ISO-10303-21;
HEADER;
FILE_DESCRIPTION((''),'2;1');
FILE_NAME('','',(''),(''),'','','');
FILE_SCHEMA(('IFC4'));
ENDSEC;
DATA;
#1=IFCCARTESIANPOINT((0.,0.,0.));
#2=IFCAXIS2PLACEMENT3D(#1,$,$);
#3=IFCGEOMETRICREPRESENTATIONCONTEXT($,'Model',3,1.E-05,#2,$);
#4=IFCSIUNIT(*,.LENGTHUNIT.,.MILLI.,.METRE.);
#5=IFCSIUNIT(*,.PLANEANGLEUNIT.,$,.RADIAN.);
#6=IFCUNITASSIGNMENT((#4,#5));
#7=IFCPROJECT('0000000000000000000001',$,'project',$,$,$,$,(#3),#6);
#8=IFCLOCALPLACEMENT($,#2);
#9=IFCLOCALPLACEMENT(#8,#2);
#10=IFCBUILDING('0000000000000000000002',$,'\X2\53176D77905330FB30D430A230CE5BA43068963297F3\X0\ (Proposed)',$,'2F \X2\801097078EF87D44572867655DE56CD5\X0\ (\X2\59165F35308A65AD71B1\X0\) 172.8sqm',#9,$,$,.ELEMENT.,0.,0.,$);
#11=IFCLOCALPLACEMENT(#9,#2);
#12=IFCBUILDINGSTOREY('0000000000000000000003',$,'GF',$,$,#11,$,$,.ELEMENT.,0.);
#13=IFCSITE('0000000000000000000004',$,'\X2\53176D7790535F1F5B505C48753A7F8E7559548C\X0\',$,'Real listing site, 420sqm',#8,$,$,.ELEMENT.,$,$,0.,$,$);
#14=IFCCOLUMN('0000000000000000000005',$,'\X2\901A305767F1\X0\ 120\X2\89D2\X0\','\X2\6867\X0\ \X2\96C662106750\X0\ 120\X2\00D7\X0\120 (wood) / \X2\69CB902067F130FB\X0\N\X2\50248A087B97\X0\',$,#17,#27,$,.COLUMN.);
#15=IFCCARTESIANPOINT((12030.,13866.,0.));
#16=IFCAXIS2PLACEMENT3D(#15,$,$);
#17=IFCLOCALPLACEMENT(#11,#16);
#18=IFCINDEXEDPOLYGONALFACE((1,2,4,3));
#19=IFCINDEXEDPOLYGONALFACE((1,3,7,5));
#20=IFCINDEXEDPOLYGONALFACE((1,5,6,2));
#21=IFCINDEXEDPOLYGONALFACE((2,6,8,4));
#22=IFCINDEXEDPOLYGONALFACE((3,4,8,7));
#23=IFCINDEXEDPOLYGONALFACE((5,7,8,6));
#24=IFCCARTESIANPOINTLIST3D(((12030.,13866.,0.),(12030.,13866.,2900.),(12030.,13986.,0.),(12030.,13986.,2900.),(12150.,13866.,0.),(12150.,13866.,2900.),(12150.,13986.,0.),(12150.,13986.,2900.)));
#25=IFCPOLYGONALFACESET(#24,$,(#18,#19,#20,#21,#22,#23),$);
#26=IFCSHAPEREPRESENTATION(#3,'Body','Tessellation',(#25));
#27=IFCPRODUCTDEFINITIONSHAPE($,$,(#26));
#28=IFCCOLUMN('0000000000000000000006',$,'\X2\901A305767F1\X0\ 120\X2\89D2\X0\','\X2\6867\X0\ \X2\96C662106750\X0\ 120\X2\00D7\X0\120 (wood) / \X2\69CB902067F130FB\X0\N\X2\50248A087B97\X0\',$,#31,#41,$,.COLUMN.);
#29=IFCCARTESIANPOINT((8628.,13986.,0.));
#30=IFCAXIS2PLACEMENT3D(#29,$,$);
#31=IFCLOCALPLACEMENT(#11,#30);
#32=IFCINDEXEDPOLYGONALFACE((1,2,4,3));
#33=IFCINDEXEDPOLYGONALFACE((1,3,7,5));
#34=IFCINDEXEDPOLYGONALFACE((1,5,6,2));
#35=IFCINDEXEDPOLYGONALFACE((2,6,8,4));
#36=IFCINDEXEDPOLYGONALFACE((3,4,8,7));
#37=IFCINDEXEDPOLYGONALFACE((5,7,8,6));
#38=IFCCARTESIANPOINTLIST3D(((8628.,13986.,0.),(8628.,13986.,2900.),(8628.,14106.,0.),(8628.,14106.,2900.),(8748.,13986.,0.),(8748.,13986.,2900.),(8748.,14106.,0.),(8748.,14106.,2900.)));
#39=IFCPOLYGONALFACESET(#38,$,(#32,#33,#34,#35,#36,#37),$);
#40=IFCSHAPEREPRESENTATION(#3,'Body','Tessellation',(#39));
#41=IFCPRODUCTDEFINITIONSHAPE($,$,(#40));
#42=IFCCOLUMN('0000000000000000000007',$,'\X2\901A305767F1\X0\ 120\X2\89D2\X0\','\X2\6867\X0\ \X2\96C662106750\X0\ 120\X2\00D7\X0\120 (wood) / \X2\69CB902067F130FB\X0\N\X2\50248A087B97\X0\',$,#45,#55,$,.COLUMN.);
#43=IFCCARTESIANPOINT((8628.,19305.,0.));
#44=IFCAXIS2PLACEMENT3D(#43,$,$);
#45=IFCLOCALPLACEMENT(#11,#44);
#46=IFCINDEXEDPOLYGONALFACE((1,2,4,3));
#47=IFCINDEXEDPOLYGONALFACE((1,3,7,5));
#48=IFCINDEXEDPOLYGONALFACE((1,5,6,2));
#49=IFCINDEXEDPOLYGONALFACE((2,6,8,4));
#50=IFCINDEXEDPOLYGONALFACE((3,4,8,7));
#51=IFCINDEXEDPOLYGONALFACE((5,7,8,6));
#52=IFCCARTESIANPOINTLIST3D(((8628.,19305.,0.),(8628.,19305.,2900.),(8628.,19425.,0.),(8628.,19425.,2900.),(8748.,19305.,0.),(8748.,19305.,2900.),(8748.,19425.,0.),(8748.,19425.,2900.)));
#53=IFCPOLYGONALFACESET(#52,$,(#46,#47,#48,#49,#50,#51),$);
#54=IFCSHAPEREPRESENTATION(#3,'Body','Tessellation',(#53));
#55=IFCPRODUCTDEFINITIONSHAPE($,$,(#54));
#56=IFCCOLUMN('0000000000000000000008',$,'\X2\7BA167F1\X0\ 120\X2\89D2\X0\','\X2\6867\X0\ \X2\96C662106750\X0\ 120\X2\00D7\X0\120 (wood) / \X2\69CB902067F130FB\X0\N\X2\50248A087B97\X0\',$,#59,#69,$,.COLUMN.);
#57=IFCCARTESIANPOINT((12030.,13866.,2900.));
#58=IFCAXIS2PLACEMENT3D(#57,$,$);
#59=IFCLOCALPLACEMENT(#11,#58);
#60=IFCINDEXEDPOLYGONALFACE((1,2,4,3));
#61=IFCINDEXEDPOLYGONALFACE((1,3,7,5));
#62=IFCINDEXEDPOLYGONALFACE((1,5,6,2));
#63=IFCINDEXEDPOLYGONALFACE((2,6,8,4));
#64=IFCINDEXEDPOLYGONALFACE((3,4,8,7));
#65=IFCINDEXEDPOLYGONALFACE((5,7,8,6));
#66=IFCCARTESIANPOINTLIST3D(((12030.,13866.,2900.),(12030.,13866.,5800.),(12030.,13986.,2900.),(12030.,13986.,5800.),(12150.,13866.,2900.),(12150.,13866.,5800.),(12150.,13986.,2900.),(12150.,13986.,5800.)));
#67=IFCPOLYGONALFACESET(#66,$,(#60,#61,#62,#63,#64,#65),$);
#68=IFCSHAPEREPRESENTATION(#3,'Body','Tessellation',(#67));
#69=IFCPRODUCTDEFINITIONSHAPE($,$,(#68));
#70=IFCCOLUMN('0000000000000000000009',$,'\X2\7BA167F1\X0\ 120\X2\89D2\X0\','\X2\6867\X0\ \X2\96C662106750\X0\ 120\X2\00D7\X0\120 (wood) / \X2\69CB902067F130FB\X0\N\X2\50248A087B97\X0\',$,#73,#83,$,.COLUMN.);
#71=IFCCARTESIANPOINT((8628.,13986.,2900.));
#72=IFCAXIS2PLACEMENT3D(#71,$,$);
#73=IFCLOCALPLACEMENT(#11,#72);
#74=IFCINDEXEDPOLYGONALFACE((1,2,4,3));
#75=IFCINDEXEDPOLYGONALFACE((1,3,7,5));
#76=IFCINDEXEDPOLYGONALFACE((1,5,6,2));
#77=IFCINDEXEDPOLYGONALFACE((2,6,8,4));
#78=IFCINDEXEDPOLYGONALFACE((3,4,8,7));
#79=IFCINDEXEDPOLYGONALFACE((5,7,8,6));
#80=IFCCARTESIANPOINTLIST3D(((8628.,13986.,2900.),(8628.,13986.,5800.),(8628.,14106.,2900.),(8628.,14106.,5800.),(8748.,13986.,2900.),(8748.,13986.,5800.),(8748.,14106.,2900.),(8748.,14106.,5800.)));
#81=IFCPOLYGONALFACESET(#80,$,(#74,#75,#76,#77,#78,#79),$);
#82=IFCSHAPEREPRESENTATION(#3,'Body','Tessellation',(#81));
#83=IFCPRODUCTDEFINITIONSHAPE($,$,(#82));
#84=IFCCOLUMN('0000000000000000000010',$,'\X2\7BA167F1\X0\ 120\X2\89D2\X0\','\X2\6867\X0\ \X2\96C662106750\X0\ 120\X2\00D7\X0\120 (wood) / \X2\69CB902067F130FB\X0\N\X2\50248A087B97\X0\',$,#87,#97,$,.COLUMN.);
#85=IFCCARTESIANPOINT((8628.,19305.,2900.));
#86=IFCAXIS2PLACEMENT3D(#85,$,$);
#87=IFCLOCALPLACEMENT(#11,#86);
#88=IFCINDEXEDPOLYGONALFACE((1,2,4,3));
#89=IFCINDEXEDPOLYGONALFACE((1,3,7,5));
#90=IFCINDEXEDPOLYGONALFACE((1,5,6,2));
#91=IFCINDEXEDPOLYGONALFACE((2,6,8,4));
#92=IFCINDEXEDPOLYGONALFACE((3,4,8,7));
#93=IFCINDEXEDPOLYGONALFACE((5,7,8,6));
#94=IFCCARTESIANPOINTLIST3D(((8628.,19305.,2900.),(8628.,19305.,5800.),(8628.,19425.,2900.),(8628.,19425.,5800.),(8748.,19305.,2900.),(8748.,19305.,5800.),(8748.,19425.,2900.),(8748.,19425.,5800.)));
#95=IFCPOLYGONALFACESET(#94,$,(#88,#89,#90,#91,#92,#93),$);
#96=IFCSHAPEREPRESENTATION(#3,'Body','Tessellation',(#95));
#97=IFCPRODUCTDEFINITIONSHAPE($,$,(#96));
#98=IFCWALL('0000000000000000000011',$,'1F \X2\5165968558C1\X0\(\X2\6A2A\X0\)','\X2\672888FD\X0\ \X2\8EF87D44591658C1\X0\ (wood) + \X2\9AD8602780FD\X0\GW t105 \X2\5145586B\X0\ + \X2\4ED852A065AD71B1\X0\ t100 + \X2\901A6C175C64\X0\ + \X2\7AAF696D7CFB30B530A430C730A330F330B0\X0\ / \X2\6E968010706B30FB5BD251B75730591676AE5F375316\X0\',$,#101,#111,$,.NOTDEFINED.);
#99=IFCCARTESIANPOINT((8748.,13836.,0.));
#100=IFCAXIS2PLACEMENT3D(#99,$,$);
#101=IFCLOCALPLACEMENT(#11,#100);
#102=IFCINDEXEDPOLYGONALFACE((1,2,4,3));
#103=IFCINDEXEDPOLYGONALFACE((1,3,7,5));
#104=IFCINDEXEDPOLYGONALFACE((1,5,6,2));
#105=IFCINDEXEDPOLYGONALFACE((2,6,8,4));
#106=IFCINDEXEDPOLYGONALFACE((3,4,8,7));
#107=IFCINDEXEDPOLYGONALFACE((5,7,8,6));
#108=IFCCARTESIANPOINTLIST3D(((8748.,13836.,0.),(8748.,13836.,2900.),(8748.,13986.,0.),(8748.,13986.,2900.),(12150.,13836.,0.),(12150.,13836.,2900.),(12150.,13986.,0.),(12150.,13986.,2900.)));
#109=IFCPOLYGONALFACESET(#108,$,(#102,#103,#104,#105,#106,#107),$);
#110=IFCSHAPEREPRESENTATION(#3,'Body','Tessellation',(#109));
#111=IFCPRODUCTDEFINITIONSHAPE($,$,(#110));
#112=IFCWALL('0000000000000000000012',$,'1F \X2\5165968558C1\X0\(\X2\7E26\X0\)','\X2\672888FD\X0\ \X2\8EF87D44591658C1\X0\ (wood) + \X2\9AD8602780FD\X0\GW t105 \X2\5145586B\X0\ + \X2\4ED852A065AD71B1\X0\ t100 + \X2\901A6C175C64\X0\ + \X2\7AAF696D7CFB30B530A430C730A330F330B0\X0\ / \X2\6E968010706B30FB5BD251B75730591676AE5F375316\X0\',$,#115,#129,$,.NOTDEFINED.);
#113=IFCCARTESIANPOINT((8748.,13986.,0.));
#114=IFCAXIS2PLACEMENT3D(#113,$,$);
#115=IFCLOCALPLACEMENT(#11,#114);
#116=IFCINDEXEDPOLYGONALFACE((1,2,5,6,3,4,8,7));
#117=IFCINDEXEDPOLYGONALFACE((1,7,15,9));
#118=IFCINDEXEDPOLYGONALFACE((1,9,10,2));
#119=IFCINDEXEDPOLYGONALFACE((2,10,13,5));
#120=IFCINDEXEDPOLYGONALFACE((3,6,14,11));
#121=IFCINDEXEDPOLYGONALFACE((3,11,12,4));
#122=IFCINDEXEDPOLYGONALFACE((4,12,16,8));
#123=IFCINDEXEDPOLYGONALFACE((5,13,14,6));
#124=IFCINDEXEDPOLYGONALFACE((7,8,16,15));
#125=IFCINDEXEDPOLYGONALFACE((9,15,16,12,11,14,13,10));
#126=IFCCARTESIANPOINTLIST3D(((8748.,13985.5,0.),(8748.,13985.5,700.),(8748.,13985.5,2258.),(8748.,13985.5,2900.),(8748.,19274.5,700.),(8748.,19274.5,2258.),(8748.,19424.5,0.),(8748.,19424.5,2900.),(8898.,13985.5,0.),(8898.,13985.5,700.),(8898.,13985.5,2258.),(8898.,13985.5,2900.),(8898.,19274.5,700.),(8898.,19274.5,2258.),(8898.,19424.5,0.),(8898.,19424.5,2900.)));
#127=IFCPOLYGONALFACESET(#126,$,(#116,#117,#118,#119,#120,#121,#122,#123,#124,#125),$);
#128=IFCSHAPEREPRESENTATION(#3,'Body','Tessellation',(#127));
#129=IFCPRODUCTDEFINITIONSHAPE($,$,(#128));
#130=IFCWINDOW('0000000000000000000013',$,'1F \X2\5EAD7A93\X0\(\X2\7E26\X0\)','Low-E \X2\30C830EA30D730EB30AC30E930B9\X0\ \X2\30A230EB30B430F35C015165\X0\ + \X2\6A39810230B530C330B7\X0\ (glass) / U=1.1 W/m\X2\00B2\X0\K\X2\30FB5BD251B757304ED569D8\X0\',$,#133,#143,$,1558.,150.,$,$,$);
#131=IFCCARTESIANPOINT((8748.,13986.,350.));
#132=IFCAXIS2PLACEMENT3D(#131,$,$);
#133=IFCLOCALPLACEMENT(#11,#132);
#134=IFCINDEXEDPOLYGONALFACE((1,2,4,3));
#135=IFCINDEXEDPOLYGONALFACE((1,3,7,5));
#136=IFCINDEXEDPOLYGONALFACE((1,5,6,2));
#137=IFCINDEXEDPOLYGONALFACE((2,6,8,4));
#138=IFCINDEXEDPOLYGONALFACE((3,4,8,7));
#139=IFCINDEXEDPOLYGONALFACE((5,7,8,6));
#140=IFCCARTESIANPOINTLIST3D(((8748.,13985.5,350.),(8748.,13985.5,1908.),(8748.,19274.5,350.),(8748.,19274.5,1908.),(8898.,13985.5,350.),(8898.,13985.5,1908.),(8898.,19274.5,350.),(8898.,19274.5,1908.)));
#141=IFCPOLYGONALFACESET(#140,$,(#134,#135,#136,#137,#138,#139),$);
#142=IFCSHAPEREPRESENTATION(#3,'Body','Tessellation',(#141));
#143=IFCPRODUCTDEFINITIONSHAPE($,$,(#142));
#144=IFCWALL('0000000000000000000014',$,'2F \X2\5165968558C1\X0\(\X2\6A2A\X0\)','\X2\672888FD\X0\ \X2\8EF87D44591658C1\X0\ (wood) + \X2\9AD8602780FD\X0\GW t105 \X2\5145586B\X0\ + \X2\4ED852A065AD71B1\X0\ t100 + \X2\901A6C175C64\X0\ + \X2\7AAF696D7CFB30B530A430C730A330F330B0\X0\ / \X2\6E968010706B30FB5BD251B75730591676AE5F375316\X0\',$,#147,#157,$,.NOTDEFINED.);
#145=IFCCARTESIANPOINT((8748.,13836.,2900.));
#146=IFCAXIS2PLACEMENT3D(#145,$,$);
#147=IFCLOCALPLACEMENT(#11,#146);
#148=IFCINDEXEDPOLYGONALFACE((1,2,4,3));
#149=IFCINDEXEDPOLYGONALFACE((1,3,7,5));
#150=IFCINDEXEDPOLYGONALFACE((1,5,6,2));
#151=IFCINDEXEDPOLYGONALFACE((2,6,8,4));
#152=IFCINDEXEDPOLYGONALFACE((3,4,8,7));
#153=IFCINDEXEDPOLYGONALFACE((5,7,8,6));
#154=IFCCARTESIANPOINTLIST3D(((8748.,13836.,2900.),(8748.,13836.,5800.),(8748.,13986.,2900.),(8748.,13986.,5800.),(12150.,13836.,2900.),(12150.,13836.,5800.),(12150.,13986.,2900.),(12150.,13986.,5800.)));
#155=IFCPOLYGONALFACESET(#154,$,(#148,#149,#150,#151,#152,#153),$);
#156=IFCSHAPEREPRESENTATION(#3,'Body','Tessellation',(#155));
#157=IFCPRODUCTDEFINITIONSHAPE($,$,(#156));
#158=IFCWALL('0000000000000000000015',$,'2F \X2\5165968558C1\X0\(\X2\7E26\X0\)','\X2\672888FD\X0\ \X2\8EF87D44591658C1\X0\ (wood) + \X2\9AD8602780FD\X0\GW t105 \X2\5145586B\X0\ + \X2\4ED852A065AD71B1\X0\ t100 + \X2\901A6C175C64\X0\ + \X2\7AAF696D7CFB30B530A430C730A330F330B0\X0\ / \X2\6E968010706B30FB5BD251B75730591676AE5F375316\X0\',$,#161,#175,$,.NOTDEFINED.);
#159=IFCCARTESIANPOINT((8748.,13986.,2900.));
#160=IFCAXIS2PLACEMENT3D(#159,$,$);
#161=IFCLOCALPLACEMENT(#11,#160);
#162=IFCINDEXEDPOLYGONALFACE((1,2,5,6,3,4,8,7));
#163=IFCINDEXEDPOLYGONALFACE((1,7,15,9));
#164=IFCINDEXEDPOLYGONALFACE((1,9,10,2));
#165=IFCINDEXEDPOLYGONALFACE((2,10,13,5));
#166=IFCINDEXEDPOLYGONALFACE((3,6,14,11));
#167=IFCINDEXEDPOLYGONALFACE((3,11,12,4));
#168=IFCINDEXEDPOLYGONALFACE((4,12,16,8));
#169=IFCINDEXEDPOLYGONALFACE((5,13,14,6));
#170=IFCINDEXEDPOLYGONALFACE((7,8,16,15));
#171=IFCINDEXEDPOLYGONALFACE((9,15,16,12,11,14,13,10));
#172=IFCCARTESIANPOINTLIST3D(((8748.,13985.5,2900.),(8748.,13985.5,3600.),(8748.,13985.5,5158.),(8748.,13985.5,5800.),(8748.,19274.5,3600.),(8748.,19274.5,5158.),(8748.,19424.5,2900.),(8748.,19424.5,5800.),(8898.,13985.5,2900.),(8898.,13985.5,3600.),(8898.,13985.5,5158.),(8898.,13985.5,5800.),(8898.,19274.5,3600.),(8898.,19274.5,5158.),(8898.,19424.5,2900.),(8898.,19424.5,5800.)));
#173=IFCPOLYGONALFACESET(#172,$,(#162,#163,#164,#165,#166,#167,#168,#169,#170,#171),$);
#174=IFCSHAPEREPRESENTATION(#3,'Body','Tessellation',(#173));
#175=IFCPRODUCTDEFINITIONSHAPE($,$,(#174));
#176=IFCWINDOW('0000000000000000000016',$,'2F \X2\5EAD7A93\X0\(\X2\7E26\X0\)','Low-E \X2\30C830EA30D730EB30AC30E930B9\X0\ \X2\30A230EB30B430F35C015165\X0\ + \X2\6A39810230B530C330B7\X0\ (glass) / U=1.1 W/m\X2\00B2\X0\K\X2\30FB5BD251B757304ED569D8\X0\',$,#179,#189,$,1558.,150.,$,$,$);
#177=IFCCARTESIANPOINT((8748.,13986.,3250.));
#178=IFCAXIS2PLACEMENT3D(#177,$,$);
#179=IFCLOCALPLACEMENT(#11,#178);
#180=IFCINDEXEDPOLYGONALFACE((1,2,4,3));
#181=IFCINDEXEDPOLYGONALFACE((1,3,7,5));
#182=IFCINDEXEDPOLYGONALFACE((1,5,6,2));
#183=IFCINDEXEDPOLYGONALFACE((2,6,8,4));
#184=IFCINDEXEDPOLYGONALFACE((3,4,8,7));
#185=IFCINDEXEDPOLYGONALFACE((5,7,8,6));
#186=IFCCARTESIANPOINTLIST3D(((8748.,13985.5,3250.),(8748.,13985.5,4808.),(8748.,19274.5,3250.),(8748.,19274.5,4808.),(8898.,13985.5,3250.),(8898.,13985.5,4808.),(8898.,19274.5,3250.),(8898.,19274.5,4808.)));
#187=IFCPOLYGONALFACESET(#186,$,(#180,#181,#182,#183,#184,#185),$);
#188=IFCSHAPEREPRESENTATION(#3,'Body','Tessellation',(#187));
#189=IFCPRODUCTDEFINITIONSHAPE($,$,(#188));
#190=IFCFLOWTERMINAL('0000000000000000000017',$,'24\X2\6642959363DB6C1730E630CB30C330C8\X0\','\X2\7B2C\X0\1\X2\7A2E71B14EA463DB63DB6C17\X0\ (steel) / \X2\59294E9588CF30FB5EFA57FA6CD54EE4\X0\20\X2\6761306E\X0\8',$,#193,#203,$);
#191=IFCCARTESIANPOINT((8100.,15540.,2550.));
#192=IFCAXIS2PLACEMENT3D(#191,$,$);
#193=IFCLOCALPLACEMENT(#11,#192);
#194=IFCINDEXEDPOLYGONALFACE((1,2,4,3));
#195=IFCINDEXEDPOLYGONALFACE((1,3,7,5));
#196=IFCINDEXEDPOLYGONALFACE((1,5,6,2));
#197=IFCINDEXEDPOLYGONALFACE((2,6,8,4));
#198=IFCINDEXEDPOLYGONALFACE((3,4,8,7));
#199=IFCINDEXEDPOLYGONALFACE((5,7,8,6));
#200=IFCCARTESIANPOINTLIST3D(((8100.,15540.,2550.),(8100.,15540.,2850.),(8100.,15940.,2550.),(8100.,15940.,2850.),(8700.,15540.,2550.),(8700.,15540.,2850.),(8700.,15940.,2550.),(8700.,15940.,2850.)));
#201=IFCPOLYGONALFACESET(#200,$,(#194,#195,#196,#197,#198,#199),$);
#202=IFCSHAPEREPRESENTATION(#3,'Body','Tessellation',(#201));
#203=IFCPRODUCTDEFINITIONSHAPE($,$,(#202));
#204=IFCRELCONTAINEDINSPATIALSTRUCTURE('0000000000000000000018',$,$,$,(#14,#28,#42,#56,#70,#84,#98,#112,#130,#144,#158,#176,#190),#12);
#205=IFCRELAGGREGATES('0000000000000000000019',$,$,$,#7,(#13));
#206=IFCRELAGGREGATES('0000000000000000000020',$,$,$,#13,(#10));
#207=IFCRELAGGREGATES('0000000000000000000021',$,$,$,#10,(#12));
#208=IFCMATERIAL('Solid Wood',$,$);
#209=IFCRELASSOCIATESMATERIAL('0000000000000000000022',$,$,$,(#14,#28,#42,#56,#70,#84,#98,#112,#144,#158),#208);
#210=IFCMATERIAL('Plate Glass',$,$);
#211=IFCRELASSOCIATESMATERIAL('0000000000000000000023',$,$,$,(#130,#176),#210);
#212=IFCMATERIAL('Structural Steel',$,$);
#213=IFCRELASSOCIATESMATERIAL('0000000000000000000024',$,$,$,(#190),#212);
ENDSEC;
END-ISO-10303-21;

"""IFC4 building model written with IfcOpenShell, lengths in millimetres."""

from ifc_helpers import new_model, si_unit, frame, frame_2d, origin, place, context, project, spatial, rectangle, extrude, material, element, fill, save


model = new_model("IFC4")

# Units and contexts
model_context = context("Model", 3, precision=1e-05, world=origin())
ifc_project = project(units=[si_unit("LENGTHUNIT", "METRE", prefix="MILLI"), si_unit("PLANEANGLEUNIT", "RADIAN")], contexts=[model_context])

# Site, building, storey
site_placement = place(None, origin())
site = spatial("IfcSite", under=ifc_project, at=site_placement, Name="北海道弟子屈町美留和", ObjectType="Real listing site, 420sqm", CompositionType="ELEMENT", RefElevation=0.0)
building_placement = place(site_placement, origin())
building = spatial("IfcBuilding", under=site, at=building_placement, Name="北海道・ピアノ室と防音 (Proposed)", ObjectType="2F 耐震軸組在来工法 (外張り断熱) 172.8sqm", CompositionType="ELEMENT", ElevationOfRefHeight=0.0, ElevationOfTerrain=0.0)
storey_placement = place(building_placement, origin())
storey = spatial("IfcBuildingStorey", under=building, at=storey_placement, Name="GF", CompositionType="ELEMENT", Elevation=0.0)

# Columns
ifc_material_1 = material(Name="Solid Wood")
column_1_placement = place(storey_placement, frame((12030.0, 13866.0, 0.0)))
element("IfcColumn", 1, at=column_1_placement, inside=storey, material=ifc_material_1, Name="通し柱 120角", Description="桧 集成材 120×120 (wood) / 構造柱・N値計算", PredefinedType="COLUMN", context=model_context, shape_type="SweptSolid", body=[
    extrude(rectangle(XDim=120.0, YDim=120.0, at=frame_2d((60.0, 60.0))), frame((12030.0, 13866.0, 0.0)), (0.0, 0.0, 1.0), 2900.0),
])
column_2_placement = place(storey_placement, frame((8628.0, 13986.0, 0.0)))
element("IfcColumn", 2, at=column_2_placement, inside=storey, material=ifc_material_1, Name="通し柱 120角", Description="桧 集成材 120×120 (wood) / 構造柱・N値計算", PredefinedType="COLUMN", context=model_context, shape_type="SweptSolid", body=[
    extrude(rectangle(XDim=120.0, YDim=120.0, at=frame_2d((60.0, 60.0))), frame((8628.0, 13986.0, 0.0)), (0.0, 0.0, 1.0), 2900.0),
])
column_3_placement = place(storey_placement, frame((8628.0, 19305.0, 0.0)))
element("IfcColumn", 3, at=column_3_placement, inside=storey, material=ifc_material_1, Name="通し柱 120角", Description="桧 集成材 120×120 (wood) / 構造柱・N値計算", PredefinedType="COLUMN", context=model_context, shape_type="SweptSolid", body=[
    extrude(rectangle(XDim=120.0, YDim=120.0, at=frame_2d((60.0, 60.0))), frame((8628.0, 19305.0, 0.0)), (0.0, 0.0, 1.0), 2900.0),
])
column_4_placement = place(storey_placement, frame((12030.0, 13866.0, 2900.0)))
element("IfcColumn", 4, at=column_4_placement, inside=storey, material=ifc_material_1, Name="管柱 120角", Description="桧 集成材 120×120 (wood) / 構造柱・N値計算", PredefinedType="COLUMN", context=model_context, shape_type="SweptSolid", body=[
    extrude(rectangle(XDim=120.0, YDim=120.0, at=frame_2d((60.0, 60.0))), frame((12030.0, 13866.0, 2900.0)), (0.0, 0.0, 1.0), 2900.0),
])
column_5_placement = place(storey_placement, frame((8628.0, 13986.0, 2900.0)))
element("IfcColumn", 5, at=column_5_placement, inside=storey, material=ifc_material_1, Name="管柱 120角", Description="桧 集成材 120×120 (wood) / 構造柱・N値計算", PredefinedType="COLUMN", context=model_context, shape_type="SweptSolid", body=[
    extrude(rectangle(XDim=120.0, YDim=120.0, at=frame_2d((60.0, 60.0))), frame((8628.0, 13986.0, 2900.0)), (0.0, 0.0, 1.0), 2900.0),
])
column_6_placement = place(storey_placement, frame((8628.0, 19305.0, 2900.0)))
element("IfcColumn", 6, at=column_6_placement, inside=storey, material=ifc_material_1, Name="管柱 120角", Description="桧 集成材 120×120 (wood) / 構造柱・N値計算", PredefinedType="COLUMN", context=model_context, shape_type="SweptSolid", body=[
    extrude(rectangle(XDim=120.0, YDim=120.0, at=frame_2d((60.0, 60.0))), frame((8628.0, 19305.0, 2900.0)), (0.0, 0.0, 1.0), 2900.0),
])

# Wall
wall_1_placement = place(storey_placement, frame((8748.0, 13836.0, 0.0)))
element("IfcWall", 7, at=wall_1_placement, inside=storey, material=ifc_material_1, Name="1F 入隅壁(横)", Description="木製 軸組外壁 (wood) + 高性能GW t105 充填 + 付加断熱 t100 + 通気層 + 窯業系サイディング / 準耐火・寒冷地外皮強化", PredefinedType="NOTDEFINED", context=model_context, shape_type="SweptSolid", body=[
    extrude(rectangle(XDim=3402.0, YDim=150.0, at=frame_2d((1701.0, 75.0))), frame((8748.0, 13836.0, 0.0)), (0.0, 0.0, 1.0), 2900.0),
])

# Wall, opening, window
wall_2_placement = place(storey_placement, frame((8748.0, 13986.0, 0.0)))
wall_2 = element("IfcWall", 8, at=wall_2_placement, inside=storey, material=ifc_material_1, Name="1F 入隅壁(縦)", Description="木製 軸組外壁 (wood) + 高性能GW t105 充填 + 付加断熱 t100 + 通気層 + 窯業系サイディング / 準耐火・寒冷地外皮強化", PredefinedType="NOTDEFINED", context=model_context, shape_type="SweptSolid", body=[
    extrude(rectangle(XDim=150.0, YDim=5439.0, at=frame_2d((75.0, 2719.0))), frame((8748.0, 13986.0, 0.0)), (0.0, 0.0, 1.0), 2900.0),
])
opening_1_placement = place(storey_placement, frame((8748.0, 13986.0, 350.0)))
opening_1 = element("IfcOpeningElement", 9, at=opening_1_placement, cuts=wall_2, PredefinedType="NOTDEFINED", context=model_context, shape_type="SweptSolid", body=[
    extrude(rectangle(XDim=150.0, YDim=5289.0, at=frame_2d((75.0, 2644.0))), frame((8748.0, 13986.0, 350.0)), (0.0, 0.0, 1.0), 1558.0),
])
ifc_material_2 = material(Name="Plate Glass")
window_1_placement = place(storey_placement, frame((8748.0, 13986.0, 350.0)))
window_1 = element("IfcWindow", 10, at=window_1_placement, inside=storey, material=ifc_material_2, Name="1F 庭窓(縦)", Description="Low-E トリプルガラス アルゴン封入 + 樹脂サッシ (glass) / U=1.1 W/m²K・寒冷地仕様", OverallHeight=1558.0, OverallWidth=150.0, context=model_context, shape_type="SweptSolid", body=[
    extrude(rectangle(XDim=150.0, YDim=5289.0, at=frame_2d((75.0, 2644.0))), frame((8748.0, 13986.0, 350.0)), (0.0, 0.0, 1.0), 1558.0),
])
fill(opening_1, window_1)

# Wall
wall_3_placement = place(storey_placement, frame((8748.0, 13836.0, 2900.0)))
element("IfcWall", 11, at=wall_3_placement, inside=storey, material=ifc_material_1, Name="2F 入隅壁(横)", Description="木製 軸組外壁 (wood) + 高性能GW t105 充填 + 付加断熱 t100 + 通気層 + 窯業系サイディング / 準耐火・寒冷地外皮強化", PredefinedType="NOTDEFINED", context=model_context, shape_type="SweptSolid", body=[
    extrude(rectangle(XDim=3402.0, YDim=150.0, at=frame_2d((1701.0, 75.0))), frame((8748.0, 13836.0, 2900.0)), (0.0, 0.0, 1.0), 2900.0),
])

# Wall, opening, window
wall_4_placement = place(storey_placement, frame((8748.0, 13986.0, 2900.0)))
wall_4 = element("IfcWall", 12, at=wall_4_placement, inside=storey, material=ifc_material_1, Name="2F 入隅壁(縦)", Description="木製 軸組外壁 (wood) + 高性能GW t105 充填 + 付加断熱 t100 + 通気層 + 窯業系サイディング / 準耐火・寒冷地外皮強化", PredefinedType="NOTDEFINED", context=model_context, shape_type="SweptSolid", body=[
    extrude(rectangle(XDim=150.0, YDim=5439.0, at=frame_2d((75.0, 2719.0))), frame((8748.0, 13986.0, 2900.0)), (0.0, 0.0, 1.0), 2900.0),
])
opening_2_placement = place(storey_placement, frame((8748.0, 13986.0, 3250.0)))
opening_2 = element("IfcOpeningElement", 13, at=opening_2_placement, cuts=wall_4, PredefinedType="NOTDEFINED", context=model_context, shape_type="SweptSolid", body=[
    extrude(rectangle(XDim=150.0, YDim=5289.0, at=frame_2d((75.0, 2644.0))), frame((8748.0, 13986.0, 3250.0)), (0.0, 0.0, 1.0), 1558.0),
])
window_2_placement = place(storey_placement, frame((8748.0, 13986.0, 3250.0)))
window_2 = element("IfcWindow", 14, at=window_2_placement, inside=storey, material=ifc_material_2, Name="2F 庭窓(縦)", Description="Low-E トリプルガラス アルゴン封入 + 樹脂サッシ (glass) / U=1.1 W/m²K・寒冷地仕様", OverallHeight=1558.0, OverallWidth=150.0, context=model_context, shape_type="SweptSolid", body=[
    extrude(rectangle(XDim=150.0, YDim=5289.0, at=frame_2d((75.0, 2644.0))), frame((8748.0, 13986.0, 3250.0)), (0.0, 0.0, 1.0), 1558.0),
])
fill(opening_2, window_2)

# Flow terminal
ifc_material_3 = material(Name="Structural Steel")
flow_terminal_placement = place(storey_placement, frame((8100.0, 15540.0, 2550.0)))
element("IfcFlowTerminal", 15, at=flow_terminal_placement, inside=storey, material=ifc_material_3, Name="24時間換気ユニット", Description="第1種熱交換換気 (steel) / 天井裏・建基法令20条の8", context=model_context, shape_type="SweptSolid", body=[
    extrude(rectangle(XDim=600.0, YDim=400.0, at=frame_2d((300.0, 200.0))), frame((8100.0, 15540.0, 2550.0)), (0.0, 0.0, 1.0), 300.0),
])

save(model, "model.ifc")
